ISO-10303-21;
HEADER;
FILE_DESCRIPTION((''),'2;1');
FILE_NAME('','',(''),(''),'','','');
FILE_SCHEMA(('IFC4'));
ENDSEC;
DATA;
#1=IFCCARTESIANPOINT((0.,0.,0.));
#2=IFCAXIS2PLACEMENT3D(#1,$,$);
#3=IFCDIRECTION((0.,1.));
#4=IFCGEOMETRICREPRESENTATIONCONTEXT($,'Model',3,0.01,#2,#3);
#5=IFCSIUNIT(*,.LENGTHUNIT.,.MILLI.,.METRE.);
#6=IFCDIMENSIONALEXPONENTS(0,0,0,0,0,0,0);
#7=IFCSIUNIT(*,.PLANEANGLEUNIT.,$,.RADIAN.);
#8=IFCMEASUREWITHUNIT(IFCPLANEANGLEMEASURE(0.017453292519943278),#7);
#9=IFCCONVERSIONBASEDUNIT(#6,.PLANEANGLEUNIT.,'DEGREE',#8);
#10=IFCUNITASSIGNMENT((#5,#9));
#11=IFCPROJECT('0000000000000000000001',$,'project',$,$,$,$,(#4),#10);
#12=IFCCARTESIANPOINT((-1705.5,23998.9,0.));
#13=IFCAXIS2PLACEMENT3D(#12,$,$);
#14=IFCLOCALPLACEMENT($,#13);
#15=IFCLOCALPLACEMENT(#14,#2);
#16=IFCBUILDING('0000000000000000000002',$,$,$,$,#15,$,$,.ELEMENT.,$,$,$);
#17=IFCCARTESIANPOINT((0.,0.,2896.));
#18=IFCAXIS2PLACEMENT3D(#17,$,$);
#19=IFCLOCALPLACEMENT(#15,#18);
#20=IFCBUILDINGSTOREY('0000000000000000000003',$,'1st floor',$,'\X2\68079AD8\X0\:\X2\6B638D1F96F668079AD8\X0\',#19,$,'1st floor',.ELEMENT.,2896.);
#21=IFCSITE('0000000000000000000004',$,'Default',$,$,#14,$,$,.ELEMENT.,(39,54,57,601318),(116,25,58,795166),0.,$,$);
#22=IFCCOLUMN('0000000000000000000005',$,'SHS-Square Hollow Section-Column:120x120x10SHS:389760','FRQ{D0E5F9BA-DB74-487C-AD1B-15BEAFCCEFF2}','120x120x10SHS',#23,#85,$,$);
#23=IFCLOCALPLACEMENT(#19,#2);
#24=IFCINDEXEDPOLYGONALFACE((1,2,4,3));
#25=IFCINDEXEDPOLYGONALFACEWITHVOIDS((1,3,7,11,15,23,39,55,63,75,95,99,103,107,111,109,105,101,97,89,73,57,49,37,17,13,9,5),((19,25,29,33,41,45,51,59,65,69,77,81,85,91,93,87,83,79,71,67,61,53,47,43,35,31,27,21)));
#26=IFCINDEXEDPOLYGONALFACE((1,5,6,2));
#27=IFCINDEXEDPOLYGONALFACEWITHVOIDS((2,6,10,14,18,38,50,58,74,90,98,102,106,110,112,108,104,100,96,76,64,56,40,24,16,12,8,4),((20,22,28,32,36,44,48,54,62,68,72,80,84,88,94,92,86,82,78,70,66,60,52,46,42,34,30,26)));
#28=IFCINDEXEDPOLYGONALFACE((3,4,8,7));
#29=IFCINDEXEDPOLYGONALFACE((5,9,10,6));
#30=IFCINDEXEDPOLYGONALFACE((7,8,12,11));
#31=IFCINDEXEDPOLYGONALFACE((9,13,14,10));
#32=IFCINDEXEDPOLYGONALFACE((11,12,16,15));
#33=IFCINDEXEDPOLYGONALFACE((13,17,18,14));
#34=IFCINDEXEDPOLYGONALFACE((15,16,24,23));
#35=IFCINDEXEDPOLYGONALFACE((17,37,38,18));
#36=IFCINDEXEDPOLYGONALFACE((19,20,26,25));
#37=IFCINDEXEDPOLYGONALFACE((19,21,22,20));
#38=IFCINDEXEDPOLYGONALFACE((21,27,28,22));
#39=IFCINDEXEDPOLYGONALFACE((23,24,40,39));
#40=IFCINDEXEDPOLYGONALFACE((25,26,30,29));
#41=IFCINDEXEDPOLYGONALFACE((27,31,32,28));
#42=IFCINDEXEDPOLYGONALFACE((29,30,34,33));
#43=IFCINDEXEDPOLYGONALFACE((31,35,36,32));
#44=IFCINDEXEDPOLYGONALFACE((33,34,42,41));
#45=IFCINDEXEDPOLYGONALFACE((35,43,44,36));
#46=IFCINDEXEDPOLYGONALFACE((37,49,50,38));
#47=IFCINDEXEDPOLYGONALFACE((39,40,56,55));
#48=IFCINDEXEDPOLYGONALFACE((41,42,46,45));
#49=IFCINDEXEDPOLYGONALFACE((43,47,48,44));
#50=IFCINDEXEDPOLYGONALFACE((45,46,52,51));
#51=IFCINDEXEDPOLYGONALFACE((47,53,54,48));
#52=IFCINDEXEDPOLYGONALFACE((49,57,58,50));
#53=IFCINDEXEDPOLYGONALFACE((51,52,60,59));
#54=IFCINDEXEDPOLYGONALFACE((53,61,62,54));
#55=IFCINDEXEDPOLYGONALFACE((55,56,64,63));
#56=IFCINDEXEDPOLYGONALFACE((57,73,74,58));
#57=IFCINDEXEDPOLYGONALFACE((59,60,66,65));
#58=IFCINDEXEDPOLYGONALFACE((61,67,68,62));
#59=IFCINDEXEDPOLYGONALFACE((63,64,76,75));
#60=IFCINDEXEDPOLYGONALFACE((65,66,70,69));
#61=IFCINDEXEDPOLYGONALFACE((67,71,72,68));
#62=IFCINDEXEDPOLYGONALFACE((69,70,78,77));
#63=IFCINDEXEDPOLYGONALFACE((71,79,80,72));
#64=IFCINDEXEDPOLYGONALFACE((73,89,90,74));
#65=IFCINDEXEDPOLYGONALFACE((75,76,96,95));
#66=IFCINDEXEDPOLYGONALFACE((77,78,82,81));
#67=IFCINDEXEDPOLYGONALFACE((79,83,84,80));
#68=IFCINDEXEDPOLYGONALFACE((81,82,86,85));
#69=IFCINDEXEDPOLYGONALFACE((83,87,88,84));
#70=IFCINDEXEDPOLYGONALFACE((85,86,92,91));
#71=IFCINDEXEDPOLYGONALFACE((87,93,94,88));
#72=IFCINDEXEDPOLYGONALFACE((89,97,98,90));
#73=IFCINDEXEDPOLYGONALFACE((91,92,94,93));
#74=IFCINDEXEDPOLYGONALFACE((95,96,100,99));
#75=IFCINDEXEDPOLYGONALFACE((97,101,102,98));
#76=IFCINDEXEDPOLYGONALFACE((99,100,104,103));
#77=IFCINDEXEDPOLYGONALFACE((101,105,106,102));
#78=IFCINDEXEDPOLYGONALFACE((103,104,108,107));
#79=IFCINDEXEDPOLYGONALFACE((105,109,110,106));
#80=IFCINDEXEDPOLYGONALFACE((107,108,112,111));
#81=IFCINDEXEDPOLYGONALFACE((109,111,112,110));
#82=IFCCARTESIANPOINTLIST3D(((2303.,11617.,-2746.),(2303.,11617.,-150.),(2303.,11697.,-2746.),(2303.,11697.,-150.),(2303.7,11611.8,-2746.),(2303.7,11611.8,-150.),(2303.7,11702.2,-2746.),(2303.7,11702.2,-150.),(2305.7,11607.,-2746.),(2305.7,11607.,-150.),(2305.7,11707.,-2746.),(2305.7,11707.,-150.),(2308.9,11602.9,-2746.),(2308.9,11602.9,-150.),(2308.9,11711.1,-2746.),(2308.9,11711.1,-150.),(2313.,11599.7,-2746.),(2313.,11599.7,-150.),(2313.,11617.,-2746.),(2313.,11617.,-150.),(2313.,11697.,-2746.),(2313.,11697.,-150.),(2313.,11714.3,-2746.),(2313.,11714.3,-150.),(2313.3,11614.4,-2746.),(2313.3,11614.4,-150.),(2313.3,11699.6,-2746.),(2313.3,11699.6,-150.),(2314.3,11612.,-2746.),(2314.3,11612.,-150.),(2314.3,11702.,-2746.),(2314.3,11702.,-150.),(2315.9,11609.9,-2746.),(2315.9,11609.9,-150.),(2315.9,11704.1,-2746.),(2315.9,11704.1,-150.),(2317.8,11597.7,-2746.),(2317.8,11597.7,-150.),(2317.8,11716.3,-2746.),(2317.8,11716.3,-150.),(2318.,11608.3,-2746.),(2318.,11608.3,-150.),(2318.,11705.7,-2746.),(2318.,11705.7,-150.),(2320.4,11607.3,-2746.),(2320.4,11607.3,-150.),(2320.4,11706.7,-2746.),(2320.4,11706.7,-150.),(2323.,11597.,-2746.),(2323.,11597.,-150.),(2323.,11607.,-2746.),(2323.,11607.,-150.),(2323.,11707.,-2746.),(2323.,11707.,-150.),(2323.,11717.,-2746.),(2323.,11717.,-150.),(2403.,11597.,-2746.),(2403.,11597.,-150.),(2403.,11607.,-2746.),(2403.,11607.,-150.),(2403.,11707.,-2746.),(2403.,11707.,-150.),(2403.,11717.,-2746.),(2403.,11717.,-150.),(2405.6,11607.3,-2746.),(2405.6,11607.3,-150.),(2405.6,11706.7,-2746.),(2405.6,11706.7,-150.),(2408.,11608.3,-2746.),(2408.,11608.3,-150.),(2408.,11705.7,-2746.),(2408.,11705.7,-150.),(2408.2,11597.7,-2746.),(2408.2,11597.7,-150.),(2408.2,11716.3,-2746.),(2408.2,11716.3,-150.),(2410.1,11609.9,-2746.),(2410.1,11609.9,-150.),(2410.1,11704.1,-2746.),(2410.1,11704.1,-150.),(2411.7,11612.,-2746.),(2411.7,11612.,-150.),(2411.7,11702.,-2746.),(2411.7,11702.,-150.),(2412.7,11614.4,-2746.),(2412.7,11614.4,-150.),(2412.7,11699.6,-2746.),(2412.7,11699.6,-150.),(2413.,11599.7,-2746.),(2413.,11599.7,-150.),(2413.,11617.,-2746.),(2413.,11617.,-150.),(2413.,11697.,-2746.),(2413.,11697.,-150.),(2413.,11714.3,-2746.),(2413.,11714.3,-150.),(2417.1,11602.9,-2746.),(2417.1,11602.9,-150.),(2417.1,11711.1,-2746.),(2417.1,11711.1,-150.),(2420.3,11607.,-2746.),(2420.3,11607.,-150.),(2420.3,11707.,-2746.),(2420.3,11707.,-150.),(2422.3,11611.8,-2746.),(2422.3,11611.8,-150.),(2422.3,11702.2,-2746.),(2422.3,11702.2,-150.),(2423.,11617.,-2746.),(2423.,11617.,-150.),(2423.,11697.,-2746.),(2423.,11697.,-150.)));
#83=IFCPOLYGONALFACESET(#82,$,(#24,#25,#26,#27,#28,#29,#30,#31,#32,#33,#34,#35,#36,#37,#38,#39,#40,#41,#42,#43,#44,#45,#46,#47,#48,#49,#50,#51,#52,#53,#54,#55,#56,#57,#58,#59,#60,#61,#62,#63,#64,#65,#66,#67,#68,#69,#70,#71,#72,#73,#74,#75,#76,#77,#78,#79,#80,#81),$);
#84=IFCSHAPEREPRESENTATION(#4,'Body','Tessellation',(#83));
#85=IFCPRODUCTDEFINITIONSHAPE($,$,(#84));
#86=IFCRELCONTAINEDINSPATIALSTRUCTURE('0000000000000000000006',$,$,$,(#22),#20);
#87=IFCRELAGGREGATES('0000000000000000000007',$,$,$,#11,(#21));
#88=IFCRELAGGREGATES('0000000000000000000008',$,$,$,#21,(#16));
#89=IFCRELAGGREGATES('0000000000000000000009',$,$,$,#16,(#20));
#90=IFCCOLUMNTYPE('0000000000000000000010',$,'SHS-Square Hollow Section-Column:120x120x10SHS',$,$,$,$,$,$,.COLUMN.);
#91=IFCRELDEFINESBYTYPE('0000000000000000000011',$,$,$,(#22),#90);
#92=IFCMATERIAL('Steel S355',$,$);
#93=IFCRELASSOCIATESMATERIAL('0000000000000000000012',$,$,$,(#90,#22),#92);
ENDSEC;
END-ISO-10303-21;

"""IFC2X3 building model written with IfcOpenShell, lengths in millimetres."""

from ifc_helpers import new_model, entity, si_unit, converted_unit, direction, frame, origin, origin_2d, place, context, project, spatial, hollow_rectangle, extrude, clip, halfspace, material, type_object, element, save


model = new_model("IFC2X3")

# Units and contexts
model_context = context("Model", 3, precision=0.01, world=origin(), true_north=direction((0.0, 1.0)))
ifc_project = project(units=[si_unit("LENGTHUNIT", "METRE", prefix="MILLI"), converted_unit("PLANEANGLEUNIT", "DEGREE", entity("IfcPlaneAngleMeasure", 0.017453292519943278), si_unit("PLANEANGLEUNIT", "RADIAN"), dimensions=[0, 0, 0, 0, 0, 0, 0])], contexts=[model_context])

# Site, building, storey
site_placement = place(None, frame((-1705.5, 23998.9, 0.0)))
site = spatial("IfcSite", under=ifc_project, at=site_placement, Name="Default", CompositionType="ELEMENT", RefLatitude=(39, 54, 57, 601318), RefLongitude=(116, 25, 58, 795166), RefElevation=0.0)
building_placement = place(site_placement, origin())
building = spatial("IfcBuilding", under=site, at=building_placement, CompositionType="ELEMENT")
storey_placement = place(building_placement, frame((0.0, 0.0, 2896.0)))
storey = spatial("IfcBuildingStorey", under=building, at=storey_placement, Name="1st floor", ObjectType="标高:正负零标高", LongName="1st floor", CompositionType="ELEMENT", Elevation=2896.0)

# Shared definitions
ifc_material_1 = material(Name="Steel S355")

# Column
column_type_1 = type_object("IfcColumnType", Name="SHS-Square Hollow Section-Column:120x120x10SHS", PredefinedType="COLUMN", material=ifc_material_1)
column_1_placement = place(storey_placement, frame((2363.0, 11657.0, -65.1), z_axis=(0.0, 0.0, 1.0), x_axis=(0.0, -1.0, 0.0)))
element("IfcColumn", 1, at=column_1_placement, inside=storey, type_object=column_type_1, material=ifc_material_1, Name="SHS-Square Hollow Section-Column:120x120x10SHS:389760", Description="FRQ{D0E5F9BA-DB74-487C-AD1B-15BEAFCCEFF2}", ObjectType="120x120x10SHS", context=model_context, shape_type="Clipping", body=[
    clip(clip(extrude(hollow_rectangle(XDim=120.0, YDim=120.0, WallThickness=10.0, InnerFilletRadius=10.0, OuterFilletRadius=20.0, at=origin_2d()), origin(), (0.0, 0.0, -1.0), 2765.7), halfspace(frame((11657.0, -2363.0, -2680.9), z_axis=(0.0, 0.0, 1.0), x_axis=(0.0, 1.0, 0.0)), True)), halfspace(frame((11657.0, -2363.0, -84.9), z_axis=(0.0, 0.0, -1.0), x_axis=(0.0, -1.0, 0.0)), True)),
])

save(model, "model.ifc")
